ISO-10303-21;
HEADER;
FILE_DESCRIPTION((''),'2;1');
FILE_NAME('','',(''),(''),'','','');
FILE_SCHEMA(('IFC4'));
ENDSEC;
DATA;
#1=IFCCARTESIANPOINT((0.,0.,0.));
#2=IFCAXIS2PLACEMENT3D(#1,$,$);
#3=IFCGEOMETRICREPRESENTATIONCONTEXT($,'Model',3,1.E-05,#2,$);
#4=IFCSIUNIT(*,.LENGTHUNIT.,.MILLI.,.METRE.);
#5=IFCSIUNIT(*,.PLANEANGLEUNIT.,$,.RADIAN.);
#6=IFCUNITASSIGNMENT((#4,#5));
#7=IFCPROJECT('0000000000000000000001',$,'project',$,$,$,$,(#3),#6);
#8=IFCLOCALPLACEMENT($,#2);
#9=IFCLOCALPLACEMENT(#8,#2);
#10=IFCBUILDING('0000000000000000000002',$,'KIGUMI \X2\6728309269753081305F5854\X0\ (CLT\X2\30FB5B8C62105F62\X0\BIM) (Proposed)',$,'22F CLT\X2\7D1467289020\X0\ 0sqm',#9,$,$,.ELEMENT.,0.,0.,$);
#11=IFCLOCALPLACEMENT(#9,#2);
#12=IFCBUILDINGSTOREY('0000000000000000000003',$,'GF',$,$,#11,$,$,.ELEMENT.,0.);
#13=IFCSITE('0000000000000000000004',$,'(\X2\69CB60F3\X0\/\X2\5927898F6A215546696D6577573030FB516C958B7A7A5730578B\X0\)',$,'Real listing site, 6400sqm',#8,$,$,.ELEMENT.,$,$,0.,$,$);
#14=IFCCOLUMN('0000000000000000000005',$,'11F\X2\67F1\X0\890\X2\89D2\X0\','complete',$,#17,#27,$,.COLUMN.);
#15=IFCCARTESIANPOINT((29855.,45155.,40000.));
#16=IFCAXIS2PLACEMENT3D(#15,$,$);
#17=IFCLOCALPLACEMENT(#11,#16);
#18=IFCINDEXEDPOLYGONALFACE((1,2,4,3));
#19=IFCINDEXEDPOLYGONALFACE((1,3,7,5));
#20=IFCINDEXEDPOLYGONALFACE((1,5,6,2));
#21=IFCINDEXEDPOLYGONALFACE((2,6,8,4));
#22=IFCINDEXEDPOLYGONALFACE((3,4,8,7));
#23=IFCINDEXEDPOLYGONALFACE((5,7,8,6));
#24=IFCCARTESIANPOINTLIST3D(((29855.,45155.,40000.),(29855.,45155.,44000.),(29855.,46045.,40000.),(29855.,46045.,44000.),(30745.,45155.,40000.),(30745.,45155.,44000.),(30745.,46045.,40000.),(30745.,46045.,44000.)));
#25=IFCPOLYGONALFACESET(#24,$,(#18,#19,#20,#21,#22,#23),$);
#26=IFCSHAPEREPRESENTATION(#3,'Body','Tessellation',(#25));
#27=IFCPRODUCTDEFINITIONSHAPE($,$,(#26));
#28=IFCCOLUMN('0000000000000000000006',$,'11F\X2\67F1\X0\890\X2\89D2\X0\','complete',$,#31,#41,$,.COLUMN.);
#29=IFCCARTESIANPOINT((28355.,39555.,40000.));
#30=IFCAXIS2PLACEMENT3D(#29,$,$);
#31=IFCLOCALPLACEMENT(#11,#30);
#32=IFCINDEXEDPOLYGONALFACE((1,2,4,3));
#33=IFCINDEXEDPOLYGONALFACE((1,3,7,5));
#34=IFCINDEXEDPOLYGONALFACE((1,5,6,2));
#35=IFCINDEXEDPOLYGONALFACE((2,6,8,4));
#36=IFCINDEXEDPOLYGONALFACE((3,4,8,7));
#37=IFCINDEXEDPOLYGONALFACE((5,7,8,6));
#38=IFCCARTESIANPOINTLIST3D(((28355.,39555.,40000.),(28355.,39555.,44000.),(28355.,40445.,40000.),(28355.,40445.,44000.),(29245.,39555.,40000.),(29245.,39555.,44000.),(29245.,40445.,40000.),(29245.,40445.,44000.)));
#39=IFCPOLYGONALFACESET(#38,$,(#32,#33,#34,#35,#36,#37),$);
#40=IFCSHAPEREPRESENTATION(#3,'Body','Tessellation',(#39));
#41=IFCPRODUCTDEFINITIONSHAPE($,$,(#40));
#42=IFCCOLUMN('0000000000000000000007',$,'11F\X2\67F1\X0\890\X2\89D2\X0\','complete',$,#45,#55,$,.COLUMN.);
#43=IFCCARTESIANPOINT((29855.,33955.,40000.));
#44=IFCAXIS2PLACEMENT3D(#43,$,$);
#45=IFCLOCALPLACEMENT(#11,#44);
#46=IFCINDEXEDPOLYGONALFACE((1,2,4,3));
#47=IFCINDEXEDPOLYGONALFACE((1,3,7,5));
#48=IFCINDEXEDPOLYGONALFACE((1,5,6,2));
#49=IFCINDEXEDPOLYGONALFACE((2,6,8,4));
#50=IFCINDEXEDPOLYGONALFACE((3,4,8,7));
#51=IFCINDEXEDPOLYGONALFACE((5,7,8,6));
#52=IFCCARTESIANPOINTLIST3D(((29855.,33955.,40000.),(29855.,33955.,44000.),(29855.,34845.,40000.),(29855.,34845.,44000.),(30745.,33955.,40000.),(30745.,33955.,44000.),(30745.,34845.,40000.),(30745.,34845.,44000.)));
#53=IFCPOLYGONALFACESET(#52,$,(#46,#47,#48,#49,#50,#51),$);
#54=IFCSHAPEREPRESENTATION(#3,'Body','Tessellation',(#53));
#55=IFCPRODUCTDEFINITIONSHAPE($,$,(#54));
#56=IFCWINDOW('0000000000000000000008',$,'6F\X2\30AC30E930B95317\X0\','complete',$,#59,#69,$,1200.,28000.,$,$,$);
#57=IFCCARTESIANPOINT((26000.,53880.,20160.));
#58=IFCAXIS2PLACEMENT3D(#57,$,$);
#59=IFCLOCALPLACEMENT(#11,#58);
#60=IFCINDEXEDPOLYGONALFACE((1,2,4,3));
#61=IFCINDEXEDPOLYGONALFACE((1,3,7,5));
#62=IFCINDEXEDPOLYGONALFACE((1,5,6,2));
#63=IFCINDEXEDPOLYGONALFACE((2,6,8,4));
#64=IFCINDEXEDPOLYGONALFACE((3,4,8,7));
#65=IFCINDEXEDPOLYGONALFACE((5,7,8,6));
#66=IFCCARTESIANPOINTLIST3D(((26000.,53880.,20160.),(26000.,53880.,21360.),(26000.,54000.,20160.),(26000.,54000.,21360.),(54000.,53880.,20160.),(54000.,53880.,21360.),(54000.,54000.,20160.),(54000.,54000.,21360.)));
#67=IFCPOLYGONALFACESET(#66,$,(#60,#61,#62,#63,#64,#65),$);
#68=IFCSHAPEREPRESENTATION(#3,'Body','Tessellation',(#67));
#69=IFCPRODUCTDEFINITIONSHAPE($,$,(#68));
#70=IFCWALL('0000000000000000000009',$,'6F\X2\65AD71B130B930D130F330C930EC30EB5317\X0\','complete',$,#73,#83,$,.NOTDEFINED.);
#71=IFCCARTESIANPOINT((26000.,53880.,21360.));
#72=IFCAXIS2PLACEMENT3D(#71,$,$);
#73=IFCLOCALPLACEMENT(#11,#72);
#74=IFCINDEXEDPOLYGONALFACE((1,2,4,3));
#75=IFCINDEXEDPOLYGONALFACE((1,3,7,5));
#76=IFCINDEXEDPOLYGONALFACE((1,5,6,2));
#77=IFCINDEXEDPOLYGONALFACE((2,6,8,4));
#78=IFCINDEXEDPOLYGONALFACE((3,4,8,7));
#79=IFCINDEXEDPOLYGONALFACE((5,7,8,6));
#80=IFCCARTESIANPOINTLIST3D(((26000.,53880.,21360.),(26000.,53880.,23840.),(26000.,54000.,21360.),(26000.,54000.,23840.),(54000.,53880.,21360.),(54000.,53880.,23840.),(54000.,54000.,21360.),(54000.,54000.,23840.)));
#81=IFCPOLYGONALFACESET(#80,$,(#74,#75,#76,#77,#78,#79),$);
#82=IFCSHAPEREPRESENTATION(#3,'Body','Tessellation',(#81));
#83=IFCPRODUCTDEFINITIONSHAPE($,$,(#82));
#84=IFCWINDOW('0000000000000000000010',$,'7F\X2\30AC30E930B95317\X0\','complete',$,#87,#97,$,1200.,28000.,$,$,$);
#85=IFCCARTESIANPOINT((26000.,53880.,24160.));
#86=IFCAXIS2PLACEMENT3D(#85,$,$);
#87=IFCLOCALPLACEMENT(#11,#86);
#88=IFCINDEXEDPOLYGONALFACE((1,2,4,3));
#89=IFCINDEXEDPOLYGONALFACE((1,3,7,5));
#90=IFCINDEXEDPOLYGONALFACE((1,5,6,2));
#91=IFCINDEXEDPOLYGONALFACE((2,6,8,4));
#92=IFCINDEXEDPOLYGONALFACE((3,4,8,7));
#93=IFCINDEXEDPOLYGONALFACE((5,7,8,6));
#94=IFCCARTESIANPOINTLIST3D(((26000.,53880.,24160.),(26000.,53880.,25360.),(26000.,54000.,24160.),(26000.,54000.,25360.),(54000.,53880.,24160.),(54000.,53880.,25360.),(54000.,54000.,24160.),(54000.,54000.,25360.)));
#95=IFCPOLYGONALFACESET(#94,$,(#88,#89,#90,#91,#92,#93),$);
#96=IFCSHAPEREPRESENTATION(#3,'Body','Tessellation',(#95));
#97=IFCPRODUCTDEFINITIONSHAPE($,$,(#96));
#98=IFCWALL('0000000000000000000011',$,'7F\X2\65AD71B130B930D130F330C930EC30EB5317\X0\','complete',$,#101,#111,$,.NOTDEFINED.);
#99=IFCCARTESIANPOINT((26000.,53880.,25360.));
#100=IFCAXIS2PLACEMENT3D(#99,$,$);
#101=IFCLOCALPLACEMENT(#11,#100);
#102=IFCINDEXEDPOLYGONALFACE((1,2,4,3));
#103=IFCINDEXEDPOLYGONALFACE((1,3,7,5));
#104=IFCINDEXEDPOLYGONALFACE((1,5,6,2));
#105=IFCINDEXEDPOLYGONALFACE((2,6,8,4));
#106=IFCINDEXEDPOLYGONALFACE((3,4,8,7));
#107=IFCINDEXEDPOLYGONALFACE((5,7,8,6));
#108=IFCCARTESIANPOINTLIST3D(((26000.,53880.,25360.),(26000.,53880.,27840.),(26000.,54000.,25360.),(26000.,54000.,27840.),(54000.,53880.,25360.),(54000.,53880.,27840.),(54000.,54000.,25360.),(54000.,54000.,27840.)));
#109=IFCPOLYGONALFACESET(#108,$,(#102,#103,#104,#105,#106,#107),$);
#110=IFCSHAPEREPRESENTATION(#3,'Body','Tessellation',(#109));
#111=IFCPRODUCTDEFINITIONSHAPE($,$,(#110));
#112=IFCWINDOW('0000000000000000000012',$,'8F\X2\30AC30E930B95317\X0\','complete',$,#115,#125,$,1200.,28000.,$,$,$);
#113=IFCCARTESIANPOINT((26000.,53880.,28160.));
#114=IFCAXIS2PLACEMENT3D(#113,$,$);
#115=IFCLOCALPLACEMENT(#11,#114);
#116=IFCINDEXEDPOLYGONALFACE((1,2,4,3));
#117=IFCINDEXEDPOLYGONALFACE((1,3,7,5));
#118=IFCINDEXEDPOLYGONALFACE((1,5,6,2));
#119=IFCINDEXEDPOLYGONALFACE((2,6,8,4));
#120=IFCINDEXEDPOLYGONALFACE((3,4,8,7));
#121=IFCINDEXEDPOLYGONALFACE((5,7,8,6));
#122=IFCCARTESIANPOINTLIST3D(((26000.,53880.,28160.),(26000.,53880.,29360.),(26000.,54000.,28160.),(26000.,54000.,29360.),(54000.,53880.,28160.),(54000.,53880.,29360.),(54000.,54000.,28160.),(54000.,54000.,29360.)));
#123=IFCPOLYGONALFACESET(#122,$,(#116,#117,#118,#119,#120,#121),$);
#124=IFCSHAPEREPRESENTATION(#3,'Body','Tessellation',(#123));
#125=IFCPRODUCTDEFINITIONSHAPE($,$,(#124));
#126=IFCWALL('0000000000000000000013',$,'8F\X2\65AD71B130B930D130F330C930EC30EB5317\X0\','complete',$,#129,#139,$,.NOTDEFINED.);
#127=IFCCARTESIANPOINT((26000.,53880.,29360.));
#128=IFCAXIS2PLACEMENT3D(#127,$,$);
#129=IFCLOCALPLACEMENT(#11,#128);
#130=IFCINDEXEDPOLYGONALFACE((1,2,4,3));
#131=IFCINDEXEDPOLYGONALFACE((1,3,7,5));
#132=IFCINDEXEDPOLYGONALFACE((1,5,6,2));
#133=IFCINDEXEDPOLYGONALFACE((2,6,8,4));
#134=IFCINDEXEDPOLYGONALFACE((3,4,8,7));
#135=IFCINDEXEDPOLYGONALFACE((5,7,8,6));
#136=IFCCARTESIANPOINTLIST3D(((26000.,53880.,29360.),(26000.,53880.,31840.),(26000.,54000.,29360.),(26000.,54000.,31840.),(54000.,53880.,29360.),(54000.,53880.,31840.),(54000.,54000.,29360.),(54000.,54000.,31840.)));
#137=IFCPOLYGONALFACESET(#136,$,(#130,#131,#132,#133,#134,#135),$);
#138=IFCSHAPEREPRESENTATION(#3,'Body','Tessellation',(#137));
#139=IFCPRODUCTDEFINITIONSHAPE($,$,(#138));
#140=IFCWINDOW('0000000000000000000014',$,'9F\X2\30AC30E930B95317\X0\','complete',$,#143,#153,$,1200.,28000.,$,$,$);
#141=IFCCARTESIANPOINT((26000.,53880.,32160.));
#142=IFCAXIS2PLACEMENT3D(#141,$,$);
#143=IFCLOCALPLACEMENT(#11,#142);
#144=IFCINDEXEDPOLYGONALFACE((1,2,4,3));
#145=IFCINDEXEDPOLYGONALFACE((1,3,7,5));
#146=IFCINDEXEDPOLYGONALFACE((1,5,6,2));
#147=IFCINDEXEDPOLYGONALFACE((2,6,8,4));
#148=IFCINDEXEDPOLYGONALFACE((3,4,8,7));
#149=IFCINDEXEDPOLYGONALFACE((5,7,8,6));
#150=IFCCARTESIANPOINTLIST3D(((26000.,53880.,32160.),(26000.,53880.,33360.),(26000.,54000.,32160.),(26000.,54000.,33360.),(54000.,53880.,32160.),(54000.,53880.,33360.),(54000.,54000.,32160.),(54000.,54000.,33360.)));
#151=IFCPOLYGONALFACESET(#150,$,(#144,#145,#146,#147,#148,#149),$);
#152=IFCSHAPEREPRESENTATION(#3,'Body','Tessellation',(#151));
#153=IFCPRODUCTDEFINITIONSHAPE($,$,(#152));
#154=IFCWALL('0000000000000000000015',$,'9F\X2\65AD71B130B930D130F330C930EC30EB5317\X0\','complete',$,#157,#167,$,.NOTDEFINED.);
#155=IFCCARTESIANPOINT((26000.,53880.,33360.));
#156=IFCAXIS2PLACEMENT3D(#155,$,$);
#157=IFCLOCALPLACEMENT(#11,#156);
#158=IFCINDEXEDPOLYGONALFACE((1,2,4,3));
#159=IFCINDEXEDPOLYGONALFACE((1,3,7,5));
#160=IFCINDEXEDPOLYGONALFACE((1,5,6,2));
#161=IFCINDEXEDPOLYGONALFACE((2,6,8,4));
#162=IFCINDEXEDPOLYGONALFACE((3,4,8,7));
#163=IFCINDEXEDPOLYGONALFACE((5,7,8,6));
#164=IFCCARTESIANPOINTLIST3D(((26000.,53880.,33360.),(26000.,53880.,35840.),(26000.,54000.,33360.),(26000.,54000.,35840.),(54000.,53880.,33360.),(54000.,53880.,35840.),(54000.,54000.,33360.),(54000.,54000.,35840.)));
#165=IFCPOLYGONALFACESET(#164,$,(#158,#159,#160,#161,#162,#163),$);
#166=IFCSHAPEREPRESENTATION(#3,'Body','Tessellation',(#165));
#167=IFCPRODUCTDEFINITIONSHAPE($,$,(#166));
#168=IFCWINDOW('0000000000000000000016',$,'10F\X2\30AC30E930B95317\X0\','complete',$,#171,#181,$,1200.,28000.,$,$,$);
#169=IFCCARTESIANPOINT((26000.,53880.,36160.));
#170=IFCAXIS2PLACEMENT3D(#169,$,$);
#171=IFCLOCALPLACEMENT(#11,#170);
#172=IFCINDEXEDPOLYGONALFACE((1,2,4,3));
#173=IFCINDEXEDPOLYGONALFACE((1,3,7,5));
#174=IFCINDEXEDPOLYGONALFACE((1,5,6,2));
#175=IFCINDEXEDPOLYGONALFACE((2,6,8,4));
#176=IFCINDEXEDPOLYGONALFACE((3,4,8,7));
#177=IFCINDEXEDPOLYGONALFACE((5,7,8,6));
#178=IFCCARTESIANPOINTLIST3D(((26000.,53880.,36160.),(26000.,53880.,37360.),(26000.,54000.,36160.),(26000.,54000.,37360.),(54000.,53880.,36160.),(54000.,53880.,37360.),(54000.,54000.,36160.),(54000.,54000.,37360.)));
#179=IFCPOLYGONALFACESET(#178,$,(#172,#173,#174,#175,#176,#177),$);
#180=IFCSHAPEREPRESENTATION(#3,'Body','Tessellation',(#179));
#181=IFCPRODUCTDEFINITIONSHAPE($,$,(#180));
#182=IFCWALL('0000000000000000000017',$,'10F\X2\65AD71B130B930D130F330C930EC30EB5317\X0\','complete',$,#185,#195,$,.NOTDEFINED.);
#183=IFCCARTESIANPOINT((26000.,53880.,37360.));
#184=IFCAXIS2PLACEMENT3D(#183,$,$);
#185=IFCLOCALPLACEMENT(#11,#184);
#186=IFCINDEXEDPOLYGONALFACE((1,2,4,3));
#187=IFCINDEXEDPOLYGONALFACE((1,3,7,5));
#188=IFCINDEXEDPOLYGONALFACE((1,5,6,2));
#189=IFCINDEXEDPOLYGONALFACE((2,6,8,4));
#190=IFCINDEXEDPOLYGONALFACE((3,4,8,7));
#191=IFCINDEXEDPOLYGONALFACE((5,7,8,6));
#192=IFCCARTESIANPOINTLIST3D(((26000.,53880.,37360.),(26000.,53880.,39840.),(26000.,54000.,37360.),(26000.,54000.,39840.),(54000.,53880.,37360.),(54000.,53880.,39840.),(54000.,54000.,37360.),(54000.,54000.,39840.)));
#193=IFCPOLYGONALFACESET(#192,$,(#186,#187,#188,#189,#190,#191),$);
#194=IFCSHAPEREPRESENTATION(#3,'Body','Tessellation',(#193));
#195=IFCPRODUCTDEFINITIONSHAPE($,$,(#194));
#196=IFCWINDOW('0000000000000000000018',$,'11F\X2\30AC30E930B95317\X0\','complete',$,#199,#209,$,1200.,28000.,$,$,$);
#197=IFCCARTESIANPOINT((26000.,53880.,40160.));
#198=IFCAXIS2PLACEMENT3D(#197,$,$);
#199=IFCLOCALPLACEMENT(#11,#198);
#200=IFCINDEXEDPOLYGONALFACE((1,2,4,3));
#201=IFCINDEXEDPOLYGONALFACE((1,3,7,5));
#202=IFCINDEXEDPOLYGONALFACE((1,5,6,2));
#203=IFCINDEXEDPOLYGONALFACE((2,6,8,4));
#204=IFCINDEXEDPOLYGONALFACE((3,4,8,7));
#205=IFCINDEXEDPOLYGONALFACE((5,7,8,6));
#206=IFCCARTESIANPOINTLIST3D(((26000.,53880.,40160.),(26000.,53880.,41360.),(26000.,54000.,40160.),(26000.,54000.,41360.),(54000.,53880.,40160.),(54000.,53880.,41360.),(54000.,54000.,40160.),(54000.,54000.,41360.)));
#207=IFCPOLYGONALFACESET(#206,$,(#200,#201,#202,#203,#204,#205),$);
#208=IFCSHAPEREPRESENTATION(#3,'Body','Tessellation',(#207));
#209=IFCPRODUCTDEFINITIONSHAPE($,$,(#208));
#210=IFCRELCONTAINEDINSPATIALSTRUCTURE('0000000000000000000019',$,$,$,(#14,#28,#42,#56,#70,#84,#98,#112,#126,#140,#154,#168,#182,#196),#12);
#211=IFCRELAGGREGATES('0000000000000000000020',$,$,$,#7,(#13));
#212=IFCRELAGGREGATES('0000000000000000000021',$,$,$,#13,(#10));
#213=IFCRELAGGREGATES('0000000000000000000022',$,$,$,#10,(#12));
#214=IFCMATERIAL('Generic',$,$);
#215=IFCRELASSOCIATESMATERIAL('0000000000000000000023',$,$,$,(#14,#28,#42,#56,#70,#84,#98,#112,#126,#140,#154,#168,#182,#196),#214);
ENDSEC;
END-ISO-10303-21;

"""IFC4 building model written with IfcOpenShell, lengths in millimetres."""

from ifc_helpers import new_model, si_unit, frame, frame_2d, origin, place, context, project, spatial, rectangle, extrude, material, element, save


model = new_model("IFC4")

# Units and contexts
model_context = context("Model", 3, precision=1e-05, world=origin())
ifc_project = project(units=[si_unit("LENGTHUNIT", "METRE", prefix="MILLI"), si_unit("PLANEANGLEUNIT", "RADIAN")], contexts=[model_context])

# Site, building, storey
site_placement = place(None, origin())
site = spatial("IfcSite", under=ifc_project, at=site_placement, Name="(構想/大規模商業敷地・公開空地型)", ObjectType="Real listing site, 6400sqm", CompositionType="ELEMENT", RefElevation=0.0)
building_placement = place(site_placement, origin())
building = spatial("IfcBuilding", under=site, at=building_placement, Name="KIGUMI 木を極めた塔 (CLT・完成形BIM) (Proposed)", ObjectType="22F CLT純木造 0sqm", CompositionType="ELEMENT", ElevationOfRefHeight=0.0, ElevationOfTerrain=0.0)
storey_placement = place(building_placement, origin())
storey = spatial("IfcBuildingStorey", under=building, at=storey_placement, Name="GF", CompositionType="ELEMENT", Elevation=0.0)

# Columns
ifc_material = material(Name="Generic")
column_1_placement = place(storey_placement, frame((29855.0, 45155.0, 40000.0)))
element("IfcColumn", 1, at=column_1_placement, inside=storey, material=ifc_material, Name="11F柱890角", Description="complete", PredefinedType="COLUMN", context=model_context, shape_type="SweptSolid", body=[
    extrude(rectangle(XDim=890.0, YDim=890.0, at=frame_2d((445.0, 445.0))), frame((29855.0, 45155.0, 40000.0)), (0.0, 0.0, 1.0), 4000.0),
])
column_2_placement = place(storey_placement, frame((28355.0, 39555.0, 40000.0)))
element("IfcColumn", 2, at=column_2_placement, inside=storey, material=ifc_material, Name="11F柱890角", Description="complete", PredefinedType="COLUMN", context=model_context, shape_type="SweptSolid", body=[
    extrude(rectangle(XDim=890.0, YDim=890.0, at=frame_2d((445.0, 445.0))), frame((28355.0, 39555.0, 40000.0)), (0.0, 0.0, 1.0), 4000.0),
])
column_3_placement = place(storey_placement, frame((29855.0, 33955.0, 40000.0)))
element("IfcColumn", 3, at=column_3_placement, inside=storey, material=ifc_material, Name="11F柱890角", Description="complete", PredefinedType="COLUMN", context=model_context, shape_type="SweptSolid", body=[
    extrude(rectangle(XDim=890.0, YDim=890.0, at=frame_2d((445.0, 445.0))), frame((29855.0, 33955.0, 40000.0)), (0.0, 0.0, 1.0), 4000.0),
])

# Window
window_1_placement = place(storey_placement, frame((26000.0, 53880.0, 20160.0)))
element("IfcWindow", 4, at=window_1_placement, inside=storey, material=ifc_material, Name="6Fガラス北", Description="complete", OverallHeight=1200.0, OverallWidth=28000.0, context=model_context, shape_type="SweptSolid", body=[
    extrude(rectangle(XDim=28000.0, YDim=120.0, at=frame_2d((14000.0, 60.0))), frame((26000.0, 53880.0, 20160.0)), (0.0, 0.0, 1.0), 1200.0),
])

# Wall
wall_1_placement = place(storey_placement, frame((26000.0, 53880.0, 21360.0)))
element("IfcWall", 5, at=wall_1_placement, inside=storey, material=ifc_material, Name="6F断熱スパンドレル北", Description="complete", PredefinedType="NOTDEFINED", context=model_context, shape_type="SweptSolid", body=[
    extrude(rectangle(XDim=28000.0, YDim=120.0, at=frame_2d((14000.0, 60.0))), frame((26000.0, 53880.0, 21360.0)), (0.0, 0.0, 1.0), 2480.0),
])

# Window
window_2_placement = place(storey_placement, frame((26000.0, 53880.0, 24160.0)))
element("IfcWindow", 6, at=window_2_placement, inside=storey, material=ifc_material, Name="7Fガラス北", Description="complete", OverallHeight=1200.0, OverallWidth=28000.0, context=model_context, shape_type="SweptSolid", body=[
    extrude(rectangle(XDim=28000.0, YDim=120.0, at=frame_2d((14000.0, 60.0))), frame((26000.0, 53880.0, 24160.0)), (0.0, 0.0, 1.0), 1200.0),
])

# Wall
wall_2_placement = place(storey_placement, frame((26000.0, 53880.0, 25360.0)))
element("IfcWall", 7, at=wall_2_placement, inside=storey, material=ifc_material, Name="7F断熱スパンドレル北", Description="complete", PredefinedType="NOTDEFINED", context=model_context, shape_type="SweptSolid", body=[
    extrude(rectangle(XDim=28000.0, YDim=120.0, at=frame_2d((14000.0, 60.0))), frame((26000.0, 53880.0, 25360.0)), (0.0, 0.0, 1.0), 2480.0),
])

# Window
window_3_placement = place(storey_placement, frame((26000.0, 53880.0, 28160.0)))
element("IfcWindow", 8, at=window_3_placement, inside=storey, material=ifc_material, Name="8Fガラス北", Description="complete", OverallHeight=1200.0, OverallWidth=28000.0, context=model_context, shape_type="SweptSolid", body=[
    extrude(rectangle(XDim=28000.0, YDim=120.0, at=frame_2d((14000.0, 60.0))), frame((26000.0, 53880.0, 28160.0)), (0.0, 0.0, 1.0), 1200.0),
])

# Wall
wall_3_placement = place(storey_placement, frame((26000.0, 53880.0, 29360.0)))
element("IfcWall", 9, at=wall_3_placement, inside=storey, material=ifc_material, Name="8F断熱スパンドレル北", Description="complete", PredefinedType="NOTDEFINED", context=model_context, shape_type="SweptSolid", body=[
    extrude(rectangle(XDim=28000.0, YDim=120.0, at=frame_2d((14000.0, 60.0))), frame((26000.0, 53880.0, 29360.0)), (0.0, 0.0, 1.0), 2480.0),
])

# Window
window_4_placement = place(storey_placement, frame((26000.0, 53880.0, 32160.0)))
element("IfcWindow", 10, at=window_4_placement, inside=storey, material=ifc_material, Name="9Fガラス北", Description="complete", OverallHeight=1200.0, OverallWidth=28000.0, context=model_context, shape_type="SweptSolid", body=[
    extrude(rectangle(XDim=28000.0, YDim=120.0, at=frame_2d((14000.0, 60.0))), frame((26000.0, 53880.0, 32160.0)), (0.0, 0.0, 1.0), 1200.0),
])

# Wall
wall_4_placement = place(storey_placement, frame((26000.0, 53880.0, 33360.0)))
element("IfcWall", 11, at=wall_4_placement, inside=storey, material=ifc_material, Name="9F断熱スパンドレル北", Description="complete", PredefinedType="NOTDEFINED", context=model_context, shape_type="SweptSolid", body=[
    extrude(rectangle(XDim=28000.0, YDim=120.0, at=frame_2d((14000.0, 60.0))), frame((26000.0, 53880.0, 33360.0)), (0.0, 0.0, 1.0), 2480.0),
])

# Window
window_5_placement = place(storey_placement, frame((26000.0, 53880.0, 36160.0)))
element("IfcWindow", 12, at=window_5_placement, inside=storey, material=ifc_material, Name="10Fガラス北", Description="complete", OverallHeight=1200.0, OverallWidth=28000.0, context=model_context, shape_type="SweptSolid", body=[
    extrude(rectangle(XDim=28000.0, YDim=120.0, at=frame_2d((14000.0, 60.0))), frame((26000.0, 53880.0, 36160.0)), (0.0, 0.0, 1.0), 1200.0),
])

# Wall
wall_5_placement = place(storey_placement, frame((26000.0, 53880.0, 37360.0)))
element("IfcWall", 13, at=wall_5_placement, inside=storey, material=ifc_material, Name="10F断熱スパンドレル北", Description="complete", PredefinedType="NOTDEFINED", context=model_context, shape_type="SweptSolid", body=[
    extrude(rectangle(XDim=28000.0, YDim=120.0, at=frame_2d((14000.0, 60.0))), frame((26000.0, 53880.0, 37360.0)), (0.0, 0.0, 1.0), 2480.0),
])

# Window
window_6_placement = place(storey_placement, frame((26000.0, 53880.0, 40160.0)))
element("IfcWindow", 14, at=window_6_placement, inside=storey, material=ifc_material, Name="11Fガラス北", Description="complete", OverallHeight=1200.0, OverallWidth=28000.0, context=model_context, shape_type="SweptSolid", body=[
    extrude(rectangle(XDim=28000.0, YDim=120.0, at=frame_2d((14000.0, 60.0))), frame((26000.0, 53880.0, 40160.0)), (0.0, 0.0, 1.0), 1200.0),
])

save(model, "model.ifc")
